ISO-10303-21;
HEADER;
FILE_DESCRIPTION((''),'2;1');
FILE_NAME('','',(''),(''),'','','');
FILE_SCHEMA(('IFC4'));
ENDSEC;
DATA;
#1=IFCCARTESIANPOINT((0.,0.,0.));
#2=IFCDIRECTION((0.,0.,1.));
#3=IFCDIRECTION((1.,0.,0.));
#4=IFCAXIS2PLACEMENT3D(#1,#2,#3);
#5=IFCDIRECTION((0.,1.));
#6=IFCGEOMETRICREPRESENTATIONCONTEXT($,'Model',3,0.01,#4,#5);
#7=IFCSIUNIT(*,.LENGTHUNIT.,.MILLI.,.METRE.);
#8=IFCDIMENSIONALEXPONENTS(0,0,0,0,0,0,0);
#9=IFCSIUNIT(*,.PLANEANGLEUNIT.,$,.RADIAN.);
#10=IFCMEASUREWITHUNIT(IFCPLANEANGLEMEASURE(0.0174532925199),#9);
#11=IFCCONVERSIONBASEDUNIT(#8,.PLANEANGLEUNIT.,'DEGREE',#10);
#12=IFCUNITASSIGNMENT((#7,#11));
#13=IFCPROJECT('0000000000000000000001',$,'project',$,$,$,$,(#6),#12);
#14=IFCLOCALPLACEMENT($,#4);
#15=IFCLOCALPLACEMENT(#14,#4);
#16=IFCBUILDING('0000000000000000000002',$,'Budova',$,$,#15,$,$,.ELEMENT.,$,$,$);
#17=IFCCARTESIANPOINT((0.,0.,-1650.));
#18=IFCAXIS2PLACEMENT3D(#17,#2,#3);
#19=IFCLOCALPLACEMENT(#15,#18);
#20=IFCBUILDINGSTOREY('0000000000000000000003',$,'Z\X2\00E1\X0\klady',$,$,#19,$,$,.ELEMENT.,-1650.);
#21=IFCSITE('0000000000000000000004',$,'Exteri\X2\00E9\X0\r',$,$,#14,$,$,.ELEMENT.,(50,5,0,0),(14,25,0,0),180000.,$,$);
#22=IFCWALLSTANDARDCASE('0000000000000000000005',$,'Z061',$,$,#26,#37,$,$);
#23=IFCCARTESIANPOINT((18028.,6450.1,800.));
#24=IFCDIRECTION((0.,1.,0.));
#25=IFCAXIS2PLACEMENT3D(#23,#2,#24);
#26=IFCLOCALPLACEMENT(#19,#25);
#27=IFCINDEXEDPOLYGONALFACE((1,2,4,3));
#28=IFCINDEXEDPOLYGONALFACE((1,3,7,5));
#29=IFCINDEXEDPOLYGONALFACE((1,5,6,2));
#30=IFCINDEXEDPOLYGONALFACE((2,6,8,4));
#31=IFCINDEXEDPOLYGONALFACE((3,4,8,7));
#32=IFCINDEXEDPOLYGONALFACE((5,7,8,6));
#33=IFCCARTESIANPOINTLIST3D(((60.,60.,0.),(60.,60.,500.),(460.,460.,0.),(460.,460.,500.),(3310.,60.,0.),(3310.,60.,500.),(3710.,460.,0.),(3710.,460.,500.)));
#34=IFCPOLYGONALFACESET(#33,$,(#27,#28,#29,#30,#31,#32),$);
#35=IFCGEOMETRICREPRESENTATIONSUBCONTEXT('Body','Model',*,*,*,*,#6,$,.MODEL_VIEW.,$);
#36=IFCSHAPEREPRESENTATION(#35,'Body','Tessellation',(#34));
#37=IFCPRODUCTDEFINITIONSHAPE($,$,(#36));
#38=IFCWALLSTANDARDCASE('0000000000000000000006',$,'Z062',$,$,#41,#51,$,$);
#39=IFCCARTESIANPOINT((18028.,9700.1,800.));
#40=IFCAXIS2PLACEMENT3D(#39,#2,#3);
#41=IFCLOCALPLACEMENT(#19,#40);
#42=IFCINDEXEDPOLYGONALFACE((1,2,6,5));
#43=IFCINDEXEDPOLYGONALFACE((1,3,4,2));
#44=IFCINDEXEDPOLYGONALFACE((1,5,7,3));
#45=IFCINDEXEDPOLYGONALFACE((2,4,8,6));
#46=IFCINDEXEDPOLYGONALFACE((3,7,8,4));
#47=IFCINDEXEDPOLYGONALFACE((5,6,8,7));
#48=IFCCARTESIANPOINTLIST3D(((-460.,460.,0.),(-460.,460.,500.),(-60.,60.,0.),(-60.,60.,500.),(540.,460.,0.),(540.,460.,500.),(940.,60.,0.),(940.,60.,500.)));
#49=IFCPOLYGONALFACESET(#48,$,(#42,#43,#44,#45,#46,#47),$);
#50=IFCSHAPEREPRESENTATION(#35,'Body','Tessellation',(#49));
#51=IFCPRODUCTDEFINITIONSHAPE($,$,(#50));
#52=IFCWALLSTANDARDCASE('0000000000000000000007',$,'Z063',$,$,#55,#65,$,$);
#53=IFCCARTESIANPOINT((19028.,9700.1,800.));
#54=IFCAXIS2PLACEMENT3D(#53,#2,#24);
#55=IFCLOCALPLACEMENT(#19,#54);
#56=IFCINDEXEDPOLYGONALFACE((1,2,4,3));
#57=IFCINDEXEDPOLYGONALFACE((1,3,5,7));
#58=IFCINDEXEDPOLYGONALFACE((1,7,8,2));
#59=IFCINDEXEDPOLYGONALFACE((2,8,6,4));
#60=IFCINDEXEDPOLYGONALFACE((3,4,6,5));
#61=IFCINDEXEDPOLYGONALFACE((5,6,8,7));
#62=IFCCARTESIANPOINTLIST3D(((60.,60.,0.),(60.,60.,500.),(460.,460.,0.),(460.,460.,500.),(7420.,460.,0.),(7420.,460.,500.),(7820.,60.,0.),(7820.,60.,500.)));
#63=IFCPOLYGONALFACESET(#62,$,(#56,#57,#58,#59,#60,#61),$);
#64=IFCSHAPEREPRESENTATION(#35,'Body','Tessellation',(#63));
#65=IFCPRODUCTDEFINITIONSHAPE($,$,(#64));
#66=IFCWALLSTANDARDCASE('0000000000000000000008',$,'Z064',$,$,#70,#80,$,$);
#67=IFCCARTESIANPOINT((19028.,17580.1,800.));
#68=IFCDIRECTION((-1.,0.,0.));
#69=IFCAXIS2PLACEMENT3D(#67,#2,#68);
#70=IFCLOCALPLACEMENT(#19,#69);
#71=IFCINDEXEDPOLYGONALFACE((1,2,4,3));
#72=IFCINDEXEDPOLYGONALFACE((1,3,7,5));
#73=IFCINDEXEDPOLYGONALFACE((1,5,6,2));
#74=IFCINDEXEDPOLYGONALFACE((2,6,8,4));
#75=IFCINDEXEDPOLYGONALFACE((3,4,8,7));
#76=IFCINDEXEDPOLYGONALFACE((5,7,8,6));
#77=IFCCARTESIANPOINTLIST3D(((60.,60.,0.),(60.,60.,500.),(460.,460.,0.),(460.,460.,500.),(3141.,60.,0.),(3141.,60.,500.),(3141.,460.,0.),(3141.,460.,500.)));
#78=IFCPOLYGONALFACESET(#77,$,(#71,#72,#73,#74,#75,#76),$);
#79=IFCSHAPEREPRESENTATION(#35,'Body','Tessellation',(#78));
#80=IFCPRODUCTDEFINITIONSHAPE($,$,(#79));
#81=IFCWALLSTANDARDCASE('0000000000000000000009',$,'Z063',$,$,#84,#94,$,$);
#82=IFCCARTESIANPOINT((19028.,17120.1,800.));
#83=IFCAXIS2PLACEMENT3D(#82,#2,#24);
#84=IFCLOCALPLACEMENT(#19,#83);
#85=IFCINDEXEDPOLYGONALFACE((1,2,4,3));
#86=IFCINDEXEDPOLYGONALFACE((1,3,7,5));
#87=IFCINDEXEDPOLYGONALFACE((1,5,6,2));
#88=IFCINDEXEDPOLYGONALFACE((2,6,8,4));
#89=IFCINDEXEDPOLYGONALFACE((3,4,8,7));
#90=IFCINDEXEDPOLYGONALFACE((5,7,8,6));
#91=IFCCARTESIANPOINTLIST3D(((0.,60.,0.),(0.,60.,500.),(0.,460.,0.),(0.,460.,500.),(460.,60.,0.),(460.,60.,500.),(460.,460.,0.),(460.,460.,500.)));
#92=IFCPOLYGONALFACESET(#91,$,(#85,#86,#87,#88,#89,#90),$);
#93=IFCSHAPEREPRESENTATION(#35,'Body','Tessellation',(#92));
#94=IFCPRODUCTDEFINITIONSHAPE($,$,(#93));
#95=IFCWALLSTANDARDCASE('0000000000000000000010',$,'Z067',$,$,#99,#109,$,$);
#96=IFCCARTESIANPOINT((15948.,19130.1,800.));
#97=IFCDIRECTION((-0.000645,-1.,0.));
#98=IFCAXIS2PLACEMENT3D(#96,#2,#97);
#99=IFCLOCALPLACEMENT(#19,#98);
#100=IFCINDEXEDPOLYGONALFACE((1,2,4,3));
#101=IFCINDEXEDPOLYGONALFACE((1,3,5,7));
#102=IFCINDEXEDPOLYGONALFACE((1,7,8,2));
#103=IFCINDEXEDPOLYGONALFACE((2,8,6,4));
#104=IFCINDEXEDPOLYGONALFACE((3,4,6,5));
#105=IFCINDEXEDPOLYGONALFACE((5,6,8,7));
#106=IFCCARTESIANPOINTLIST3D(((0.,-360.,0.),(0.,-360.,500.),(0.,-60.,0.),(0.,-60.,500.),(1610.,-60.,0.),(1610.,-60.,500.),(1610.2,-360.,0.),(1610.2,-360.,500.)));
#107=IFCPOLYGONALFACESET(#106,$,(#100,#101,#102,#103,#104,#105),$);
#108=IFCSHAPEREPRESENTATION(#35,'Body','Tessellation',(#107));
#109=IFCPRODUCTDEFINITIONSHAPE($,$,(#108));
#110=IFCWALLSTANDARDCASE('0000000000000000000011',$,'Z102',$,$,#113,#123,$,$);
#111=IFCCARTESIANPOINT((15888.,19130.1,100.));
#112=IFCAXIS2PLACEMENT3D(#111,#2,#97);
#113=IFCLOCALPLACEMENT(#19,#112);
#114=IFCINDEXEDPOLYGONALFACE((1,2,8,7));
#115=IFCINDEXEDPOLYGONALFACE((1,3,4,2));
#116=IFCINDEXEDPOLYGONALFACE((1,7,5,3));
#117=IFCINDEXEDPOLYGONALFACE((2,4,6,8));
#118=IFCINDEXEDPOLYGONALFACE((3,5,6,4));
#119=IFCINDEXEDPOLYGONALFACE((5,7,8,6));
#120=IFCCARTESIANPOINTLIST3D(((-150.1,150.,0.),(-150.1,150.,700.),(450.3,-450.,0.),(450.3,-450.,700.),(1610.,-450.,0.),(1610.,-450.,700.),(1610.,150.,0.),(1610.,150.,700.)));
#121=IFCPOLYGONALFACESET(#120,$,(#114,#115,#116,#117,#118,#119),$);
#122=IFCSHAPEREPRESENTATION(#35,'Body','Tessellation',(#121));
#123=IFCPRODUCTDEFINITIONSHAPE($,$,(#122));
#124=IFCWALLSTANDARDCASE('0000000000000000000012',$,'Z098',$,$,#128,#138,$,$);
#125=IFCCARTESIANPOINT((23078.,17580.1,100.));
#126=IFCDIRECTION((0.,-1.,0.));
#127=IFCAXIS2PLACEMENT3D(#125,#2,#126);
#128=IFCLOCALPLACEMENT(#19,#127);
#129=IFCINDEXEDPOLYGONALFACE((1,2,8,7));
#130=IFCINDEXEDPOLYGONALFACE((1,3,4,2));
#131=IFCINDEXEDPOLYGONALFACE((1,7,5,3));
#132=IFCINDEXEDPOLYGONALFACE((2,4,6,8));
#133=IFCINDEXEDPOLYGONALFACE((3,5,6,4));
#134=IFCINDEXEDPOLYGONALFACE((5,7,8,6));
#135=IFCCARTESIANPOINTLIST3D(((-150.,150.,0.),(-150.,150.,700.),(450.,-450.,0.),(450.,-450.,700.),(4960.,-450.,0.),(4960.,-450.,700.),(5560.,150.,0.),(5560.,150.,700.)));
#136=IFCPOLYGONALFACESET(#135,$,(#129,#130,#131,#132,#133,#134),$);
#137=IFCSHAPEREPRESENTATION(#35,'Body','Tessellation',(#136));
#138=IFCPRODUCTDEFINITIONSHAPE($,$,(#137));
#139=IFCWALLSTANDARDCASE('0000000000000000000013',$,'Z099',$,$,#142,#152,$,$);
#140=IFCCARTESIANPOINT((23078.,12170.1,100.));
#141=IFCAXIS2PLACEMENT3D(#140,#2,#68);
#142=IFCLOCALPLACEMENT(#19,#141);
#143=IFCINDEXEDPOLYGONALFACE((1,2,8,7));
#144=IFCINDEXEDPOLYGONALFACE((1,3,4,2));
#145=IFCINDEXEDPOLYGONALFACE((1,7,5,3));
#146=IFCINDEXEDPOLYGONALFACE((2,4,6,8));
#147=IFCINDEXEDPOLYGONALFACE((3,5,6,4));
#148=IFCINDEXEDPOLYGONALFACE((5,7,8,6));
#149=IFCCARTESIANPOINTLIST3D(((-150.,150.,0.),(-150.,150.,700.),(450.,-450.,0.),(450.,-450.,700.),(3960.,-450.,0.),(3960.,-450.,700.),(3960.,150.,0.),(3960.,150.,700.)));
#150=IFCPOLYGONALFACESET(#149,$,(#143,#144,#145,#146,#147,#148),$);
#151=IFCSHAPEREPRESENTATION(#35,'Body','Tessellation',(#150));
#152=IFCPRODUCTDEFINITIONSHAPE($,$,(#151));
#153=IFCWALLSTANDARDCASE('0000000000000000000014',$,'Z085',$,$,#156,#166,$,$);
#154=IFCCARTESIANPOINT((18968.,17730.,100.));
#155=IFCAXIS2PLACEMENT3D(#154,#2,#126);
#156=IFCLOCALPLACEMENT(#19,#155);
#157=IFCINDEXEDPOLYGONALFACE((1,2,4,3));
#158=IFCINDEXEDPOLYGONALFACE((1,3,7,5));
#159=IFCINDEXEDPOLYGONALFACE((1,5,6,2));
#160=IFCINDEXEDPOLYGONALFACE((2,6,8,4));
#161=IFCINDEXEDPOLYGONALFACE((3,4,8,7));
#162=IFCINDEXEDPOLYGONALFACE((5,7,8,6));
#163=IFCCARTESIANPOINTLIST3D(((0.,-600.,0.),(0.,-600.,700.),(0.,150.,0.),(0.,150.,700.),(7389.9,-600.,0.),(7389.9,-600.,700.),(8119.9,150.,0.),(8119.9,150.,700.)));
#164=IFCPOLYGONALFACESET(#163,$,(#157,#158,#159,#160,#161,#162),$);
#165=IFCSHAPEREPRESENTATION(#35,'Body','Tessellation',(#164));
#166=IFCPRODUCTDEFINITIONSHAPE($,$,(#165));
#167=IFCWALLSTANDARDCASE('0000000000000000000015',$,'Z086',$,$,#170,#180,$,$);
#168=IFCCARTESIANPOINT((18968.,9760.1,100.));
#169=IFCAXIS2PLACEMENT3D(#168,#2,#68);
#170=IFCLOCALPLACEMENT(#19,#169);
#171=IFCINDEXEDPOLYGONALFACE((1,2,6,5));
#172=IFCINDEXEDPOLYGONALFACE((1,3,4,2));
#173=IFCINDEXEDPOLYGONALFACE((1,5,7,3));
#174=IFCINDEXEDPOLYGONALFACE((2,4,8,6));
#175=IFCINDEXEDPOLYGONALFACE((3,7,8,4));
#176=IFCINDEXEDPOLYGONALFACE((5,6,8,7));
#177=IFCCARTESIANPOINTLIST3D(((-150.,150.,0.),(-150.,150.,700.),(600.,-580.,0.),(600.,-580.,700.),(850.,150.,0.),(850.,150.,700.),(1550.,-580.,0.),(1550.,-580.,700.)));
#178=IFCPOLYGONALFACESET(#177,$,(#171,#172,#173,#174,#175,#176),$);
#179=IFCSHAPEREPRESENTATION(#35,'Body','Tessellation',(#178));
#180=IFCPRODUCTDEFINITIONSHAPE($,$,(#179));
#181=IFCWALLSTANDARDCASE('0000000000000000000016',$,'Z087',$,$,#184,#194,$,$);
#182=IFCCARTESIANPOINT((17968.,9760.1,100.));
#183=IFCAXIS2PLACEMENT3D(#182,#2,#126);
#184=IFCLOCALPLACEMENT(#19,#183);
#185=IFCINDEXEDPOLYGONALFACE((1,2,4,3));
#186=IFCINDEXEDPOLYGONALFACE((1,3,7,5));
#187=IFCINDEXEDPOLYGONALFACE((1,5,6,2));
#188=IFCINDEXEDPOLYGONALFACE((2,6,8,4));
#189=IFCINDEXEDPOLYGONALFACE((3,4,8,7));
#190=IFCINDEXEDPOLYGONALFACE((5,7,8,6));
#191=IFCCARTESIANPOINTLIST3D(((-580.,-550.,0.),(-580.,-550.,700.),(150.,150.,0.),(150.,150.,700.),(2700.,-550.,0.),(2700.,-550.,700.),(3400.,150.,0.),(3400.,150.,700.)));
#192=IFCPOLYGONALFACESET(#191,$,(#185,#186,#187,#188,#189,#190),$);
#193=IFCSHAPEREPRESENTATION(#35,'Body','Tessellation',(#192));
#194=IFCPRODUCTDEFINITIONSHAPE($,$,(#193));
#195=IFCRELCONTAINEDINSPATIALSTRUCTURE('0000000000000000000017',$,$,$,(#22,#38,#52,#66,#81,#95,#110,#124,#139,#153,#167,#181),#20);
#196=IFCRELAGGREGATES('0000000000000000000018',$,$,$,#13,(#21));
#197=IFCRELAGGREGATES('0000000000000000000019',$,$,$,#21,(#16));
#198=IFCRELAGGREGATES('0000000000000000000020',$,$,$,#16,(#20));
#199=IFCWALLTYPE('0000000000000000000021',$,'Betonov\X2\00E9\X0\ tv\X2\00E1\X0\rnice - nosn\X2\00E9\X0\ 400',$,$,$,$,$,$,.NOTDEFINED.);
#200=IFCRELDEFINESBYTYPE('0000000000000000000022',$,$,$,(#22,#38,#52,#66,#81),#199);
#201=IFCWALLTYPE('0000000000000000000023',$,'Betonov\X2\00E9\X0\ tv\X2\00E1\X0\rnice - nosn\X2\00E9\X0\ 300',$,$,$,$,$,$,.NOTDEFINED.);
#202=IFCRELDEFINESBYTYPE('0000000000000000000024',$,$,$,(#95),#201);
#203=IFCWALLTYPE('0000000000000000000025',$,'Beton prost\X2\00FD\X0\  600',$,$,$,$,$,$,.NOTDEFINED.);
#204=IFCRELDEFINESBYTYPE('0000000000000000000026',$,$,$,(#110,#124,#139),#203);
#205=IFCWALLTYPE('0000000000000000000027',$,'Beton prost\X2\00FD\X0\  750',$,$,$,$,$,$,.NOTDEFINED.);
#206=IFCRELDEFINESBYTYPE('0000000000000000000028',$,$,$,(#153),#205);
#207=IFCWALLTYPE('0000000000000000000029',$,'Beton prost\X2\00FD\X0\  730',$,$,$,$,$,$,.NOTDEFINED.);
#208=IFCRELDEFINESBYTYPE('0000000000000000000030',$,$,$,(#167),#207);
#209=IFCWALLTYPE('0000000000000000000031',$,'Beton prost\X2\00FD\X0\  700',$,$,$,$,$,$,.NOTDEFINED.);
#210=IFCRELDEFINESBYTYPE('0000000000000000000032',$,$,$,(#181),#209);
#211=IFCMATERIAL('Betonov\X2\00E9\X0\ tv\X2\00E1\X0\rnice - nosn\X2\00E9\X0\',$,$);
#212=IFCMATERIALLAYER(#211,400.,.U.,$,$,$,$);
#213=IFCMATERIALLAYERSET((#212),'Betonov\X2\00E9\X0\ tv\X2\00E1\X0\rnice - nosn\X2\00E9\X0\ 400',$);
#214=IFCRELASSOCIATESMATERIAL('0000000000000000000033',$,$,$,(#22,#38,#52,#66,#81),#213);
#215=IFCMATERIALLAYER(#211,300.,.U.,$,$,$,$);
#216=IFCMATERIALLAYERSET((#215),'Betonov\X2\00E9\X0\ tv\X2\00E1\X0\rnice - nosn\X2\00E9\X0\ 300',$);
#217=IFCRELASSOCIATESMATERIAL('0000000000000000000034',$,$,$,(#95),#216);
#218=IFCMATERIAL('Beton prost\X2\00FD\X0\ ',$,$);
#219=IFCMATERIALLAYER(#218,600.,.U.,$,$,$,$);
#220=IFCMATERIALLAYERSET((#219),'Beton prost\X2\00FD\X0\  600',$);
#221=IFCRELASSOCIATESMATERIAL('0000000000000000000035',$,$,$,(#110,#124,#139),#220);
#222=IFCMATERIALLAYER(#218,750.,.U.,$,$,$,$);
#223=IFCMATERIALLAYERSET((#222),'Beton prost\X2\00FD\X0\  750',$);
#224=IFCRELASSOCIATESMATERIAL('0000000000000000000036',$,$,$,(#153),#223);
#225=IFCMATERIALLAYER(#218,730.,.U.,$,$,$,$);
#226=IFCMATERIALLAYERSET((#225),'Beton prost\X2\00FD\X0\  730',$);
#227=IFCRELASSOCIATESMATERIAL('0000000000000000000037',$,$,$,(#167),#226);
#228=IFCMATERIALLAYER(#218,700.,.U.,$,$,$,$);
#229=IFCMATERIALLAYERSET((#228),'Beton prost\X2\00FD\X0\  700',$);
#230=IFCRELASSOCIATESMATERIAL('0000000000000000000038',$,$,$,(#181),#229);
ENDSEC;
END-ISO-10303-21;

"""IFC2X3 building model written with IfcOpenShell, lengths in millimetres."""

from ifc_helpers import new_model, entity, si_unit, converted_unit, direction, frame, origin_with_axes, place, context, subcontext, project, spatial, polyline, outline, extrude, material, layer, layer_set, layer_usage, type_object, element, save


model = new_model("IFC2X3")

# Units and contexts
model_context = context("Model", 3, precision=0.01, world=origin_with_axes(), true_north=direction((0.0, 1.0)))
body_context = subcontext(model_context, "Body", "Model", "MODEL_VIEW")
ifc_project = project(units=[si_unit("LENGTHUNIT", "METRE", prefix="MILLI"), converted_unit("PLANEANGLEUNIT", "DEGREE", entity("IfcPlaneAngleMeasure", 0.0174532925199), si_unit("PLANEANGLEUNIT", "RADIAN"), dimensions=[0, 0, 0, 0, 0, 0, 0])], contexts=[model_context])

# Site, building, storey
site_placement = place(None, origin_with_axes())
site = spatial("IfcSite", under=ifc_project, at=site_placement, Name="Exteriér", CompositionType="ELEMENT", RefLatitude=(50, 5, 0, 0), RefLongitude=(14, 25, 0, 0), RefElevation=180000.0)
building_placement = place(site_placement, origin_with_axes())
building = spatial("IfcBuilding", under=site, at=building_placement, Name="Budova", CompositionType="ELEMENT")
storey_placement = place(building_placement, frame((0.0, 0.0, -1650.0), z_axis=(0.0, 0.0, 1.0), x_axis=(1.0, 0.0, 0.0)))
storey = spatial("IfcBuildingStorey", under=building, at=storey_placement, Name="Základy", CompositionType="ELEMENT", Elevation=-1650.0)

# Walls
ifc_material_1 = material(Name="Betonové tvárnice - nosné")
ifc_layer_1 = layer(ifc_material_1, 400.0, ventilated="UNKNOWN")
ifc_layer_set_1 = layer_set([ifc_layer_1], Name="Betonové tvárnice - nosné 400")
ifc_layer_usage_1 = layer_usage(ifc_layer_set_1, "AXIS2", "POSITIVE", 60.0)
wall_type_1 = type_object("IfcWallType", Name="Betonové tvárnice - nosné 400", PredefinedType="NOTDEFINED")
wall_1_placement = place(storey_placement, frame((18028.0, 6450.1, 800.0), z_axis=(0.0, 0.0, 1.0), x_axis=(0.0, 1.0, 0.0)))
element("IfcWallStandardCase", 1, at=wall_1_placement, inside=storey, type_object=wall_type_1, material=ifc_layer_usage_1, Name="Z061", context=body_context, shape_type="SweptSolid", body=[
    extrude(outline(polyline([(60.0, 60.0), (3310.0, 60.0), (3710.0, 460.0), (460.0, 460.0), (60.0, 60.0)])), origin_with_axes(), (0.0, 0.0, 1.0), 500.0),
])
ifc_layer_usage_2 = layer_usage(ifc_layer_set_1, "AXIS2", "POSITIVE", 60.0)
wall_2_placement = place(storey_placement, frame((18028.0, 9700.1, 800.0), z_axis=(0.0, 0.0, 1.0), x_axis=(1.0, 0.0, 0.0)))
element("IfcWallStandardCase", 2, at=wall_2_placement, inside=storey, type_object=wall_type_1, material=ifc_layer_usage_2, Name="Z062", context=body_context, shape_type="SweptSolid", body=[
    extrude(outline(polyline([(-60.0, 60.0), (940.0, 60.0), (540.0, 460.0), (-460.0, 460.0), (-60.0, 60.0)])), origin_with_axes(), (0.0, 0.0, 1.0), 500.0),
])
ifc_layer_usage_3 = layer_usage(ifc_layer_set_1, "AXIS2", "POSITIVE", 60.0)
wall_3_placement = place(storey_placement, frame((19028.0, 9700.1, 800.0), z_axis=(0.0, 0.0, 1.0), x_axis=(0.0, 1.0, 0.0)))
element("IfcWallStandardCase", 3, at=wall_3_placement, inside=storey, type_object=wall_type_1, material=ifc_layer_usage_3, Name="Z063", context=body_context, shape_type="SweptSolid", body=[
    extrude(outline(polyline([(60.0, 60.0), (7820.0, 60.0), (7420.0, 460.0), (460.0, 460.0), (60.0, 60.0)])), origin_with_axes(), (0.0, 0.0, 1.0), 500.0),
])
ifc_layer_usage_4 = layer_usage(ifc_layer_set_1, "AXIS2", "POSITIVE", 60.0)
wall_4_placement = place(storey_placement, frame((19028.0, 17580.1, 800.0), z_axis=(0.0, 0.0, 1.0), x_axis=(-1.0, 0.0, 0.0)))
element("IfcWallStandardCase", 4, at=wall_4_placement, inside=storey, type_object=wall_type_1, material=ifc_layer_usage_4, Name="Z064", context=body_context, shape_type="SweptSolid", body=[
    extrude(outline(polyline([(60.0, 60.0), (3141.0, 60.0), (3141.0, 460.0), (460.0, 460.0), (60.0, 60.0)])), origin_with_axes(), (0.0, 0.0, 1.0), 500.0),
])
ifc_layer_usage_5 = layer_usage(ifc_layer_set_1, "AXIS2", "POSITIVE", 60.0)
wall_5_placement = place(storey_placement, frame((19028.0, 17120.1, 800.0), z_axis=(0.0, 0.0, 1.0), x_axis=(0.0, 1.0, 0.0)))
element("IfcWallStandardCase", 5, at=wall_5_placement, inside=storey, type_object=wall_type_1, material=ifc_layer_usage_5, Name="Z063", context=body_context, shape_type="SweptSolid", body=[
    extrude(outline(polyline([(0.0, 60.0), (460.0, 60.0), (460.0, 460.0), (0.0, 460.0), (0.0, 60.0)])), origin_with_axes(), (0.0, 0.0, 1.0), 500.0),
])
ifc_layer_2 = layer(ifc_material_1, 300.0, ventilated="UNKNOWN")
ifc_layer_set_2 = layer_set([ifc_layer_2], Name="Betonové tvárnice - nosné 300")
ifc_layer_usage_6 = layer_usage(ifc_layer_set_2, "AXIS2", "POSITIVE", -360.0)
wall_type_2 = type_object("IfcWallType", Name="Betonové tvárnice - nosné 300", PredefinedType="NOTDEFINED")
wall_6_placement = place(storey_placement, frame((15948.0, 19130.1, 800.0), z_axis=(0.0, 0.0, 1.0), x_axis=(-0.000645, -1.0, 0.0)))
element("IfcWallStandardCase", 6, at=wall_6_placement, inside=storey, type_object=wall_type_2, material=ifc_layer_usage_6, Name="Z067", context=body_context, shape_type="SweptSolid", body=[
    extrude(outline(polyline([(0.0, -360.0), (1610.2, -360.0), (1610.0, -60.0), (0.0, -60.0), (0.0, -360.0)])), origin_with_axes(), (0.0, 0.0, 1.0), 500.0),
])
ifc_material_2 = material(Name="Beton prostý ")
ifc_layer_3 = layer(ifc_material_2, 600.0, ventilated="UNKNOWN")
ifc_layer_set_3 = layer_set([ifc_layer_3], Name="Beton prostý  600")
ifc_layer_usage_7 = layer_usage(ifc_layer_set_3, "AXIS2", "POSITIVE", -450.0)
wall_type_3 = type_object("IfcWallType", Name="Beton prostý  600", PredefinedType="NOTDEFINED")
wall_7_placement = place(storey_placement, frame((15888.0, 19130.1, 100.0), z_axis=(0.0, 0.0, 1.0), x_axis=(-0.000645, -1.0, 0.0)))
element("IfcWallStandardCase", 7, at=wall_7_placement, inside=storey, type_object=wall_type_3, material=ifc_layer_usage_7, Name="Z102", context=body_context, shape_type="SweptSolid", body=[
    extrude(outline(polyline([(450.3, -450.0), (1610.0, -450.0), (1610.0, 150.0), (-150.1, 150.0), (450.3, -450.0)])), origin_with_axes(), (0.0, 0.0, 1.0), 700.0),
])
ifc_layer_usage_8 = layer_usage(ifc_layer_set_3, "AXIS2", "POSITIVE", -450.0)
wall_8_placement = place(storey_placement, frame((23078.0, 17580.1, 100.0), z_axis=(0.0, 0.0, 1.0), x_axis=(0.0, -1.0, 0.0)))
element("IfcWallStandardCase", 8, at=wall_8_placement, inside=storey, type_object=wall_type_3, material=ifc_layer_usage_8, Name="Z098", context=body_context, shape_type="SweptSolid", body=[
    extrude(outline(polyline([(450.0, -450.0), (4960.0, -450.0), (5560.0, 150.0), (-150.0, 150.0), (450.0, -450.0)])), origin_with_axes(), (0.0, 0.0, 1.0), 700.0),
])
ifc_layer_usage_9 = layer_usage(ifc_layer_set_3, "AXIS2", "POSITIVE", -450.0)
wall_9_placement = place(storey_placement, frame((23078.0, 12170.1, 100.0), z_axis=(0.0, 0.0, 1.0), x_axis=(-1.0, 0.0, 0.0)))
element("IfcWallStandardCase", 9, at=wall_9_placement, inside=storey, type_object=wall_type_3, material=ifc_layer_usage_9, Name="Z099", context=body_context, shape_type="SweptSolid", body=[
    extrude(outline(polyline([(450.0, -450.0), (3960.0, -450.0), (3960.0, 150.0), (-150.0, 150.0), (450.0, -450.0)])), origin_with_axes(), (0.0, 0.0, 1.0), 700.0),
])
ifc_layer_4 = layer(ifc_material_2, 750.0, ventilated="UNKNOWN")
ifc_layer_set_4 = layer_set([ifc_layer_4], Name="Beton prostý  750")
ifc_layer_usage_10 = layer_usage(ifc_layer_set_4, "AXIS2", "POSITIVE", -600.0)
wall_type_4 = type_object("IfcWallType", Name="Beton prostý  750", PredefinedType="NOTDEFINED")
wall_10_placement = place(storey_placement, frame((18968.0, 17730.0, 100.0), z_axis=(0.0, 0.0, 1.0), x_axis=(0.0, -1.0, 0.0)))
element("IfcWallStandardCase", 10, at=wall_10_placement, inside=storey, type_object=wall_type_4, material=ifc_layer_usage_10, Name="Z085", context=body_context, shape_type="SweptSolid", body=[
    extrude(outline(polyline([(0.0, -600.0), (7389.9, -600.0), (8119.9, 150.0), (0.0, 150.0), (0.0, -600.0)])), origin_with_axes(), (0.0, 0.0, 1.0), 700.0),
])
ifc_layer_5 = layer(ifc_material_2, 730.0, ventilated="UNKNOWN")
ifc_layer_set_5 = layer_set([ifc_layer_5], Name="Beton prostý  730")
ifc_layer_usage_11 = layer_usage(ifc_layer_set_5, "AXIS2", "POSITIVE", -580.0)
wall_type_5 = type_object("IfcWallType", Name="Beton prostý  730", PredefinedType="NOTDEFINED")
wall_11_placement = place(storey_placement, frame((18968.0, 9760.1, 100.0), z_axis=(0.0, 0.0, 1.0), x_axis=(-1.0, 0.0, 0.0)))
element("IfcWallStandardCase", 11, at=wall_11_placement, inside=storey, type_object=wall_type_5, material=ifc_layer_usage_11, Name="Z086", context=body_context, shape_type="SweptSolid", body=[
    extrude(outline(polyline([(600.0, -580.0), (1550.0, -580.0), (850.0, 150.0), (-150.0, 150.0), (600.0, -580.0)])), origin_with_axes(), (0.0, 0.0, 1.0), 700.0),
])
ifc_layer_6 = layer(ifc_material_2, 700.0, ventilated="UNKNOWN")
ifc_layer_set_6 = layer_set([ifc_layer_6], Name="Beton prostý  700")
ifc_layer_usage_12 = layer_usage(ifc_layer_set_6, "AXIS2", "POSITIVE", -550.0)
wall_type_6 = type_object("IfcWallType", Name="Beton prostý  700", PredefinedType="NOTDEFINED")
wall_12_placement = place(storey_placement, frame((17968.0, 9760.1, 100.0), z_axis=(0.0, 0.0, 1.0), x_axis=(0.0, -1.0, 0.0)))
element("IfcWallStandardCase", 12, at=wall_12_placement, inside=storey, type_object=wall_type_6, material=ifc_layer_usage_12, Name="Z087", context=body_context, shape_type="SweptSolid", body=[
    extrude(outline(polyline([(-580.0, -550.0), (2700.0, -550.0), (3400.0, 150.0), (150.0, 150.0), (-580.0, -550.0)])), origin_with_axes(), (0.0, 0.0, 1.0), 700.0),
])

save(model, "model.ifc")
